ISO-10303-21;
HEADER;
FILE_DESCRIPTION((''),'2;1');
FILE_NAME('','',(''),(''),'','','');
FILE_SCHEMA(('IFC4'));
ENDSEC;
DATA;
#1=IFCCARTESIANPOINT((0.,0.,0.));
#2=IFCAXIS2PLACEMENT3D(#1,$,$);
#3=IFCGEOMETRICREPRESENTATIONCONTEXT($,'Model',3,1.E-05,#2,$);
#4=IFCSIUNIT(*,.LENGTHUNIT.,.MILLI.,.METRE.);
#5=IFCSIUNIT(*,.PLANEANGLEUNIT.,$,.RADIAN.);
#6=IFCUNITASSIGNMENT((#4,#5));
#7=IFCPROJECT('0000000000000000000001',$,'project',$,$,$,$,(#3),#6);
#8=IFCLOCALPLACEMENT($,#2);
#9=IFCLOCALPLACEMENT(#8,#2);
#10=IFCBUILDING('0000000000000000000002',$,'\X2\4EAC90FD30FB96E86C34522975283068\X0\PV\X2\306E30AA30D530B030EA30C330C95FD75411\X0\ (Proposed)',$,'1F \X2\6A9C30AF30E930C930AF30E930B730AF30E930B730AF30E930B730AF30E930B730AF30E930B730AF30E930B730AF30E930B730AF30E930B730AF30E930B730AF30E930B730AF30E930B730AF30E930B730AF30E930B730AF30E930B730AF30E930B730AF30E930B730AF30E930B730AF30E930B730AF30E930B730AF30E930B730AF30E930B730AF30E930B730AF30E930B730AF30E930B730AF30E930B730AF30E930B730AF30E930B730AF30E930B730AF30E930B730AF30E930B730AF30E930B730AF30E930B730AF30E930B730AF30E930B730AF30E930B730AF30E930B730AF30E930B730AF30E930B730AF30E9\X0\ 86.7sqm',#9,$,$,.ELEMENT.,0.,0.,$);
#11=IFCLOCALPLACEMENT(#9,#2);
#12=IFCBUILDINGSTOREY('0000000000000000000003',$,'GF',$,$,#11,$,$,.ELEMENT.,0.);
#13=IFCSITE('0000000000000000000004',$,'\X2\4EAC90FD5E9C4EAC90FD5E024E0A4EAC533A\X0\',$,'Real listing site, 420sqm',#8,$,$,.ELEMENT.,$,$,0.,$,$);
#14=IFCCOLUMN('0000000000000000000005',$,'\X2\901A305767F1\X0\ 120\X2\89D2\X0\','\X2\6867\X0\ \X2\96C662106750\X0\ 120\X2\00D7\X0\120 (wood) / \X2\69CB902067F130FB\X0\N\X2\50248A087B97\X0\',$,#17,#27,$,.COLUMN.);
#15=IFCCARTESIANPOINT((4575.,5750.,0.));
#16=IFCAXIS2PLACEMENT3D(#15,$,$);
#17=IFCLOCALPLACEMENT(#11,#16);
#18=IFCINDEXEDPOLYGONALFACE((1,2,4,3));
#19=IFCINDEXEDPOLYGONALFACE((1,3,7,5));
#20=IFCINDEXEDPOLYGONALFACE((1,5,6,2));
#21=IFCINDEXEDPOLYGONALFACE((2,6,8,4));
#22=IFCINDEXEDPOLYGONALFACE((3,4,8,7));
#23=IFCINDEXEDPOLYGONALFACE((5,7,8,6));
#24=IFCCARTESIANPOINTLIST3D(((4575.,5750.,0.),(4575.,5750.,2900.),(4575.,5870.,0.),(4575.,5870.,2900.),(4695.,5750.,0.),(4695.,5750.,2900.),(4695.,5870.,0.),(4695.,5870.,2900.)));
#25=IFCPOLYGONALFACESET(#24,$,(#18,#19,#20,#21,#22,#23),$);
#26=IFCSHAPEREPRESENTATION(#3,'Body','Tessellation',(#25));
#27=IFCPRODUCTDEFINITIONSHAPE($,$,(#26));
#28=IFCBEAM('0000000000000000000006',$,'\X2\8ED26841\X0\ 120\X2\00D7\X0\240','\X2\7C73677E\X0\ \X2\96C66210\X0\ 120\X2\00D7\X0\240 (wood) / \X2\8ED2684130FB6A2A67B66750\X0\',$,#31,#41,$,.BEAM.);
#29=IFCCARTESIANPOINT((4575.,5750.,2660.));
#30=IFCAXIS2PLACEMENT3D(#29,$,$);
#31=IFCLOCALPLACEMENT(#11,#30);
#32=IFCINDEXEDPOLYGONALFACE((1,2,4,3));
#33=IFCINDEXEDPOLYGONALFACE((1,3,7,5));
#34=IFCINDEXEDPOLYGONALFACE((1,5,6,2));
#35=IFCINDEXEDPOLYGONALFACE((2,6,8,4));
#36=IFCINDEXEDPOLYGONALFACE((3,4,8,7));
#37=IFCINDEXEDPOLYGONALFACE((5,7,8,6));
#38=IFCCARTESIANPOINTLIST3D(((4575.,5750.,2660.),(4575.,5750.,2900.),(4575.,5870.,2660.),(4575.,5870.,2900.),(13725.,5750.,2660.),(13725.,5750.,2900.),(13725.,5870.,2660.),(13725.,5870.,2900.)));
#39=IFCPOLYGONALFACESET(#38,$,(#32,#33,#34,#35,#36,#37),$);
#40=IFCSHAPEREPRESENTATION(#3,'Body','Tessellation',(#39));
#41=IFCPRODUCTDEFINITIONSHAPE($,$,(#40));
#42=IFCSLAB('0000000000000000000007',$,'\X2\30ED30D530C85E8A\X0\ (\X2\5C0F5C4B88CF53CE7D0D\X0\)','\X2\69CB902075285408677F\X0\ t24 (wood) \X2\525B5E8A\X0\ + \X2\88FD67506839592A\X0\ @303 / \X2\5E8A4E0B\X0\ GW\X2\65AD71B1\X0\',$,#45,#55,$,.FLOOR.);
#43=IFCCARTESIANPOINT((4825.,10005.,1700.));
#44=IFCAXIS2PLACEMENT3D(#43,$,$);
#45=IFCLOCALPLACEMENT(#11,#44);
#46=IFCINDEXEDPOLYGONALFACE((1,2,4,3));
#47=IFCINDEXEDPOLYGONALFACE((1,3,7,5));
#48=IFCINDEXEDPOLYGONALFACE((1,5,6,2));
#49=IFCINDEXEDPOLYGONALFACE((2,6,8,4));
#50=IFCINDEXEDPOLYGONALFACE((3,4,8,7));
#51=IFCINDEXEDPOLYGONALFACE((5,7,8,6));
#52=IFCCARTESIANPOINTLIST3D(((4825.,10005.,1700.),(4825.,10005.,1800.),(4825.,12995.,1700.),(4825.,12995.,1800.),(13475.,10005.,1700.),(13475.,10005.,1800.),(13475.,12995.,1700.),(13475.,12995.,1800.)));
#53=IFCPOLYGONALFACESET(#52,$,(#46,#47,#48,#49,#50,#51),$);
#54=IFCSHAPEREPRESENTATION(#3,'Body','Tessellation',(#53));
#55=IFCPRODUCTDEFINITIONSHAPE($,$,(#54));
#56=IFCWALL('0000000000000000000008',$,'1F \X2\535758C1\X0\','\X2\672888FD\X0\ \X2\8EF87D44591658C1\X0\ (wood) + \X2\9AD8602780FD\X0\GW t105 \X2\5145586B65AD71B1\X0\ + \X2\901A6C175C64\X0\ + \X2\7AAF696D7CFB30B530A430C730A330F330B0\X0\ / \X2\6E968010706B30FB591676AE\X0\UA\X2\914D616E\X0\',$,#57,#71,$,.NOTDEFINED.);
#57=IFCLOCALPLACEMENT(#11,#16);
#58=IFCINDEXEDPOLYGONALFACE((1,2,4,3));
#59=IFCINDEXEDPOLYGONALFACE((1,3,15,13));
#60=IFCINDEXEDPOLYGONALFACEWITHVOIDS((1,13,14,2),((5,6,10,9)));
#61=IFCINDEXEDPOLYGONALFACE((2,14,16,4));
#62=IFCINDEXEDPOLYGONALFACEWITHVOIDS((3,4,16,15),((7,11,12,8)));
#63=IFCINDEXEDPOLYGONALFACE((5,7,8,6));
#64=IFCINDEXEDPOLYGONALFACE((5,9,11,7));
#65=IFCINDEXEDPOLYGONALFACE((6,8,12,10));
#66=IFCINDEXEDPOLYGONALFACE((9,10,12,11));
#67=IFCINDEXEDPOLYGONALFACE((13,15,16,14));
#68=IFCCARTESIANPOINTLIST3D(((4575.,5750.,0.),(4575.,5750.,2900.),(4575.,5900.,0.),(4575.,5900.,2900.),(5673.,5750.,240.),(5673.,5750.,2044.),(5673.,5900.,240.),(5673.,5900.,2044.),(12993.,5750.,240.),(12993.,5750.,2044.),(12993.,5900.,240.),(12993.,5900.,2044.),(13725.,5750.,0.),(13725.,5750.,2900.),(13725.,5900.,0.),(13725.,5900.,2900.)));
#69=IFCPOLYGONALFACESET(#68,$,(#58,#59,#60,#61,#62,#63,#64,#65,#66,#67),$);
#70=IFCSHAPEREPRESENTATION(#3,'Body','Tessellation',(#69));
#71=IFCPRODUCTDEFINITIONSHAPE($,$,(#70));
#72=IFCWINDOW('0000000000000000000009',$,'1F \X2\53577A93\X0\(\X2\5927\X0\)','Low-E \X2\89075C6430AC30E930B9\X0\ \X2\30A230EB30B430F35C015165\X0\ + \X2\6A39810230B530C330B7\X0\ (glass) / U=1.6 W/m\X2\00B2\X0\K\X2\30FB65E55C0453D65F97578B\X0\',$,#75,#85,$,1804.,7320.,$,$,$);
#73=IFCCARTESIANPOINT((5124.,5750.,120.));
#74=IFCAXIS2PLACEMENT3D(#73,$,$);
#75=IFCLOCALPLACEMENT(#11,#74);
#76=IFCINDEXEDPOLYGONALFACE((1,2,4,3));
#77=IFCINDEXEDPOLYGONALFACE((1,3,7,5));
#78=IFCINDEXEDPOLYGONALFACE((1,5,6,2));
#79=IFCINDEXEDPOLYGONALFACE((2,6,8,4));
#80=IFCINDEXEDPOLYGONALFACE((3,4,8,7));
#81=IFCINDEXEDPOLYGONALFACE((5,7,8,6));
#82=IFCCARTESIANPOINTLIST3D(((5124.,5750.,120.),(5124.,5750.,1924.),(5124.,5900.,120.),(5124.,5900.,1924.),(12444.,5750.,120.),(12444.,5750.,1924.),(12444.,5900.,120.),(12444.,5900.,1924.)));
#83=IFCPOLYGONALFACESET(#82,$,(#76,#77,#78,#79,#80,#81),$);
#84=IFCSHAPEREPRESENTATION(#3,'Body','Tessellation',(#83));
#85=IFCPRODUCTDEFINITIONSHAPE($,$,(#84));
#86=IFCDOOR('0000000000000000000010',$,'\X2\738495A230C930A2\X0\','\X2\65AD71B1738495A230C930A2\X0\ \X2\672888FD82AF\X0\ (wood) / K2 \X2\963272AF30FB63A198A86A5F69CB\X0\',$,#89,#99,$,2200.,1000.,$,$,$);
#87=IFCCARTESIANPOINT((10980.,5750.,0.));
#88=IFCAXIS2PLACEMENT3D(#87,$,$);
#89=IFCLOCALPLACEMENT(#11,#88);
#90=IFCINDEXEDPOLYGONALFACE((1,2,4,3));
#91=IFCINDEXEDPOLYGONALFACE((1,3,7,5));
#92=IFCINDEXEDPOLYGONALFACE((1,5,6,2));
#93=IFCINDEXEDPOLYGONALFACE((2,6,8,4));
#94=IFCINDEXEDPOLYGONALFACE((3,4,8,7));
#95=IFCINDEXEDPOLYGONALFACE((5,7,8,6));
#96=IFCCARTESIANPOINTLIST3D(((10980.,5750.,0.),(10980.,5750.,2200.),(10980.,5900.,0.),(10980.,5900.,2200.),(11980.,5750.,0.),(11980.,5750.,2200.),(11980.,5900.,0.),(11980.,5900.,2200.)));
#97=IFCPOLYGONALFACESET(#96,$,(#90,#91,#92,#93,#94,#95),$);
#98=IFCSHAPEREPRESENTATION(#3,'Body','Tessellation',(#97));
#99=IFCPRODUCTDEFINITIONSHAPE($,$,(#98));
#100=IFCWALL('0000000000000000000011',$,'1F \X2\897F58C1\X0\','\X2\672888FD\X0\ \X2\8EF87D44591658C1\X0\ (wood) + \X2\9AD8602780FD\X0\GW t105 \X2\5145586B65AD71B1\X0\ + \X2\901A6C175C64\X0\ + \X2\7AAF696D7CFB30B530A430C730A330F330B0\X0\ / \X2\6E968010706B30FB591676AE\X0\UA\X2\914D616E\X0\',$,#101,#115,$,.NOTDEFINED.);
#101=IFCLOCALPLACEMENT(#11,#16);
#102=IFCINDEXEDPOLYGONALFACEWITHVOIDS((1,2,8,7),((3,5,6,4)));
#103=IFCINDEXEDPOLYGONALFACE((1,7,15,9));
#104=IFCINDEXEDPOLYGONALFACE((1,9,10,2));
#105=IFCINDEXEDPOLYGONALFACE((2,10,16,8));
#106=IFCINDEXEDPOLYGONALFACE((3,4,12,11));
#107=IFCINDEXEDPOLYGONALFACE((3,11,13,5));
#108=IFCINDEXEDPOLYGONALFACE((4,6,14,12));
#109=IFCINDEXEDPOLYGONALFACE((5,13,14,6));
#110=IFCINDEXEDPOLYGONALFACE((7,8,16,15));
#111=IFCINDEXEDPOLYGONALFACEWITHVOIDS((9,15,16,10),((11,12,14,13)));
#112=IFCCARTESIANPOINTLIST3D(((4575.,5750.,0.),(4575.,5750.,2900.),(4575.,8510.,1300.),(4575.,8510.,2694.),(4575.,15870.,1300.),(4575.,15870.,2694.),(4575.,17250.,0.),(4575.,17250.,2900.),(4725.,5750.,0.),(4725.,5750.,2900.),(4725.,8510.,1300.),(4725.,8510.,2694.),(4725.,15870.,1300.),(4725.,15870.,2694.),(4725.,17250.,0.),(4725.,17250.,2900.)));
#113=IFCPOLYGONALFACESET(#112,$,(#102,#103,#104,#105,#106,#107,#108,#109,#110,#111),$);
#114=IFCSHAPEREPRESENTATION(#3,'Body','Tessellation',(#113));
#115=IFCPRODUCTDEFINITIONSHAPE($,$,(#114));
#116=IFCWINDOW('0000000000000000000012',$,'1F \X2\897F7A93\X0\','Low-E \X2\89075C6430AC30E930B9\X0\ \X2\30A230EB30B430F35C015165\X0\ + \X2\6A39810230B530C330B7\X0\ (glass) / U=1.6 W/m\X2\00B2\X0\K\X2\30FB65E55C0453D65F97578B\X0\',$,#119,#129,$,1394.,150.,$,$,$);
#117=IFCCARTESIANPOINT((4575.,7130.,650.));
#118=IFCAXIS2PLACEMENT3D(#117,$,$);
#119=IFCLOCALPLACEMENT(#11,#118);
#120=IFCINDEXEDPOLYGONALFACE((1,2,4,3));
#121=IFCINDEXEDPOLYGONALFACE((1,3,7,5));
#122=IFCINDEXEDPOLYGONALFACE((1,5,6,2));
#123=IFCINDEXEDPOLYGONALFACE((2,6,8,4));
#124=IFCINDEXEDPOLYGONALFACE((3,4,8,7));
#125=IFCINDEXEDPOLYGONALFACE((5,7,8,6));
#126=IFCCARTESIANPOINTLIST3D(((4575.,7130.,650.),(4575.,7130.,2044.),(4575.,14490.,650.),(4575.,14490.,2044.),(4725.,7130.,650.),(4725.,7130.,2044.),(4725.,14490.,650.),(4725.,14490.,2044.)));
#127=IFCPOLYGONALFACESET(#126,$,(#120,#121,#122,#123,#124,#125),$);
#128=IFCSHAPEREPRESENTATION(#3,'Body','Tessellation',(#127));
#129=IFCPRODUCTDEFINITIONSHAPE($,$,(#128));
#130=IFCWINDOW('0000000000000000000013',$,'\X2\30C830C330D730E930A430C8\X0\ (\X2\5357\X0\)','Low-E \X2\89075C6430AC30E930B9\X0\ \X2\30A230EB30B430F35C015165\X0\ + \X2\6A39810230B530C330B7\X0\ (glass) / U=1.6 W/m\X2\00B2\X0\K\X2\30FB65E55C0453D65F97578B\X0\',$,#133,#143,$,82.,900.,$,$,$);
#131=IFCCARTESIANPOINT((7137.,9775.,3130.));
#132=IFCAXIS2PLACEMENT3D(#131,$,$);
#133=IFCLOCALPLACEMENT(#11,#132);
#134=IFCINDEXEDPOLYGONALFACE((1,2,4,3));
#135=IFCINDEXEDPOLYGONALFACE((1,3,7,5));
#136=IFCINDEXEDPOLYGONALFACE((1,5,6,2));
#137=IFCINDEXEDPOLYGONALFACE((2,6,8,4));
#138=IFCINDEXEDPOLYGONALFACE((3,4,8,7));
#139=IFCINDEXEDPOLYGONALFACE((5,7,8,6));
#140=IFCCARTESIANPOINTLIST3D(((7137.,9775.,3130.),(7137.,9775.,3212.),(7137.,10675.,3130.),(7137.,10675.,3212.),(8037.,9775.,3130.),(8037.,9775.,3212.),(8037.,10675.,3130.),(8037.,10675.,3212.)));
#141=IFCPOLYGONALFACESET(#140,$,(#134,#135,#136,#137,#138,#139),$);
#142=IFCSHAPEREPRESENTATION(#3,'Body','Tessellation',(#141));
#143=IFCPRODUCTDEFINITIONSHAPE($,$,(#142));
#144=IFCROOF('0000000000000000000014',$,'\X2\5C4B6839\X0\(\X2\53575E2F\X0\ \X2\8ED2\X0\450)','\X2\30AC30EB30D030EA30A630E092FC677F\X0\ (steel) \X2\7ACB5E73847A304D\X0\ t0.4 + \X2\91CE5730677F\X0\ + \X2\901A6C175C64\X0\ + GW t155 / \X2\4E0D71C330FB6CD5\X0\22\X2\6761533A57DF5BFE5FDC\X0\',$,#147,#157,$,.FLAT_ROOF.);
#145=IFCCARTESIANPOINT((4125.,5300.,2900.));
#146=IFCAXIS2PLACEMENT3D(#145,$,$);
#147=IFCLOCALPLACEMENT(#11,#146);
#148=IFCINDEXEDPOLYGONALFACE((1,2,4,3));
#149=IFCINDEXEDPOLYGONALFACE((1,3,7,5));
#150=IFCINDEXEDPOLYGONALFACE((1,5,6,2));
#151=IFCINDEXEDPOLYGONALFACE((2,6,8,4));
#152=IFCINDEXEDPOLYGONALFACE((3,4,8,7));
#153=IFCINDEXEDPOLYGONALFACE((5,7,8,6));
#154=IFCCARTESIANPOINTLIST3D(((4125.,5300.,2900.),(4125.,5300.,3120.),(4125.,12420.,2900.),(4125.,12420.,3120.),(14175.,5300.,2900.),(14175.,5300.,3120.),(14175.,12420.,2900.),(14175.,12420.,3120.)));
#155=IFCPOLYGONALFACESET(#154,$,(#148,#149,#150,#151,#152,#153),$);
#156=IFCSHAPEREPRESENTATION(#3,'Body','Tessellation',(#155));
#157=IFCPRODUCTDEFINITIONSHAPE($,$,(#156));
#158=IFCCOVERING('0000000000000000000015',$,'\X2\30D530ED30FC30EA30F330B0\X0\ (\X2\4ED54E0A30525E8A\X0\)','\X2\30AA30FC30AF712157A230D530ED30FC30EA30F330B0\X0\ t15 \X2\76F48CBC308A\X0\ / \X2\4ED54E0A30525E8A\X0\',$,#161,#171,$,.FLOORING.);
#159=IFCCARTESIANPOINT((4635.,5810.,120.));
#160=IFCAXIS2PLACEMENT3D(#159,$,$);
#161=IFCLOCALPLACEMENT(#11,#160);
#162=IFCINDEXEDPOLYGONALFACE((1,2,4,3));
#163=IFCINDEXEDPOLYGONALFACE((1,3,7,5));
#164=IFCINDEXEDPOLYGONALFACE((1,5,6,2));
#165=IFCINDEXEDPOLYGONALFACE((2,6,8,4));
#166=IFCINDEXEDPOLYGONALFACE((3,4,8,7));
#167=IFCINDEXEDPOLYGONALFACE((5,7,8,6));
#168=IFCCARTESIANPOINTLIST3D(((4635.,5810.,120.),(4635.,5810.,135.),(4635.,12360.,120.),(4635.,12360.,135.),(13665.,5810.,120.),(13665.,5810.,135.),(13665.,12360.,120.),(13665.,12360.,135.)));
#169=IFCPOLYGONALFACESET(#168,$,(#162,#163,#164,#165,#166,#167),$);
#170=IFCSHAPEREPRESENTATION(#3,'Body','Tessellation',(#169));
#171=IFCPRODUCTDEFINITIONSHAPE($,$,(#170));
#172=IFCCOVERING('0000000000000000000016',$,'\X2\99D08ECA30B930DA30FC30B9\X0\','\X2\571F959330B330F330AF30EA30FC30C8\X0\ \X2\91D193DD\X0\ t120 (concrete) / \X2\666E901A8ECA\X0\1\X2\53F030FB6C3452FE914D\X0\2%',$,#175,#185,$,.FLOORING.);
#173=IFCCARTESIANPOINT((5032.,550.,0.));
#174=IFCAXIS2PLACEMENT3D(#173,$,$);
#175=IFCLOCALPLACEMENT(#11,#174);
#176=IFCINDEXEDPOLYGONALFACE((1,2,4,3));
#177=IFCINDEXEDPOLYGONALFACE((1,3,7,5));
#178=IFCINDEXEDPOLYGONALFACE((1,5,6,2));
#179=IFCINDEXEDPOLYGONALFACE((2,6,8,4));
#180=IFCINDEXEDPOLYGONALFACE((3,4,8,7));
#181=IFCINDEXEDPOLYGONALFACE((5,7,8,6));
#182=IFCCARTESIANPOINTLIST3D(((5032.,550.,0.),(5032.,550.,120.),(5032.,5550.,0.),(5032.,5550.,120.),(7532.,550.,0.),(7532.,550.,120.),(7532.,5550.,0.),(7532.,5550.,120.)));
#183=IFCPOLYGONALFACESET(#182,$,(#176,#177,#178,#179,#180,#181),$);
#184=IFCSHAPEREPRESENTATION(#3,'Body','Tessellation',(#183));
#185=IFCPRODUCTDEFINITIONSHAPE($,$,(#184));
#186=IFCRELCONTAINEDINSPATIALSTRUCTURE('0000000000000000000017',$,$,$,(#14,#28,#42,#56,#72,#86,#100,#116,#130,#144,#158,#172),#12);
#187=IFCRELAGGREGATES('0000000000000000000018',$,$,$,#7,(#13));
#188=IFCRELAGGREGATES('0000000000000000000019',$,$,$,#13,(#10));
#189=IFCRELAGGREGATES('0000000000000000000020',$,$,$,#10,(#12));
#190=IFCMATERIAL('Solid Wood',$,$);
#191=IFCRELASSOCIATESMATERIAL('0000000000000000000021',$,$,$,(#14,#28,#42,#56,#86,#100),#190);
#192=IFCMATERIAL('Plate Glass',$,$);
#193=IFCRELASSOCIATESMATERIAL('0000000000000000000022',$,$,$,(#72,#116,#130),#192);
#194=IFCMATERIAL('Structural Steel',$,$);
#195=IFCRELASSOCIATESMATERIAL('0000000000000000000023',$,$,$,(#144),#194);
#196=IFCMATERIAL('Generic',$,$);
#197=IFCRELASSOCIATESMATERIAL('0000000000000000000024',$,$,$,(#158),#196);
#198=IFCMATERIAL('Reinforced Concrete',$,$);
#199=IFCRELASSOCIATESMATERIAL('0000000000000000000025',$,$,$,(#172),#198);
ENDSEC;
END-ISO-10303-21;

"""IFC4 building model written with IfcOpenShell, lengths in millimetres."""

from ifc_helpers import new_model, si_unit, frame, frame_2d, origin, place, context, project, spatial, rectangle, extrude, material, element, fill, save


model = new_model("IFC4")

# Units and contexts
model_context = context("Model", 3, precision=1e-05, world=origin())
ifc_project = project(units=[si_unit("LENGTHUNIT", "METRE", prefix="MILLI"), si_unit("PLANEANGLEUNIT", "RADIAN")], contexts=[model_context])

# Site, building, storey
site_placement = place(None, origin())
site = spatial("IfcSite", under=ifc_project, at=site_placement, Name="京都府京都市上京区", ObjectType="Real listing site, 420sqm", CompositionType="ELEMENT", RefElevation=0.0)
building_placement = place(site_placement, origin())
building = spatial("IfcBuilding", under=site, at=building_placement, Name="京都・雨水利用とPVのオフグリッド志向 (Proposed)", ObjectType="1F 檜クラドクラシクラシクラシクラシクラシクラシクラシクラシクラシクラシクラシクラシクラシクラシクラシクラシクラシクラシクラシクラシクラシクラシクラシクラシクラシクラシクラシクラシクラシクラシクラシクラシクラシクラシクラシクラシクラシクラシクラ 86.7sqm", CompositionType="ELEMENT", ElevationOfRefHeight=0.0, ElevationOfTerrain=0.0)
storey_placement = place(building_placement, origin())
storey = spatial("IfcBuildingStorey", under=building, at=storey_placement, Name="GF", CompositionType="ELEMENT", Elevation=0.0)

# Column
ifc_material_1 = material(Name="Solid Wood")
column_1_placement = place(storey_placement, frame((4575.0, 5750.0, 0.0)))
element("IfcColumn", 1, at=column_1_placement, inside=storey, material=ifc_material_1, Name="通し柱 120角", Description="桧 集成材 120×120 (wood) / 構造柱・N値計算", PredefinedType="COLUMN", context=model_context, shape_type="SweptSolid", body=[
    extrude(rectangle(XDim=120.0, YDim=120.0, at=frame_2d((60.0, 60.0))), frame((4575.0, 5750.0, 0.0)), (0.0, 0.0, 1.0), 2900.0),
])

# Beam
beam_1_placement = place(storey_placement, frame((4575.0, 5750.0, 2660.0)))
element("IfcBeam", 2, at=beam_1_placement, inside=storey, material=ifc_material_1, Name="軒桁 120×240", Description="米松 集成 120×240 (wood) / 軒桁・横架材", PredefinedType="BEAM", context=model_context, shape_type="SweptSolid", body=[
    extrude(rectangle(XDim=9150.0, YDim=120.0, at=frame_2d((4575.0, 60.0))), frame((4575.0, 5750.0, 2660.0)), (0.0, 0.0, 1.0), 240.0),
])

# Slab
ifc_material_2 = material(Name="Reinforced Concrete")
slab_1_placement = place(storey_placement, frame((4825.0, 10005.0, 1700.0)))
element("IfcSlab", 3, at=slab_1_placement, inside=storey, material=ifc_material_1, Name="ロフト床 (小屋裏収納)", Description="構造用合板 t24 (wood) 剛床 + 製材根太 @303 / 床下 GW断熱", PredefinedType="FLOOR", context=model_context, shape_type="SweptSolid", body=[
    extrude(rectangle(XDim=8650.0, YDim=2990.0, at=frame_2d((4325.0, 1495.0))), frame((4825.0, 10005.0, 1700.0)), (0.0, 0.0, 1.0), 100.0),
])

# Wall, openings, window, door
wall_1_placement = place(storey_placement, frame((4575.0, 5750.0, 0.0)))
wall_1 = element("IfcWall", 4, at=wall_1_placement, inside=storey, material=ifc_material_1, Name="1F 南壁", Description="木製 軸組外壁 (wood) + 高性能GW t105 充填断熱 + 通気層 + 窯業系サイディング / 準耐火・外皮UA配慮", PredefinedType="NOTDEFINED", context=model_context, shape_type="SweptSolid", body=[
    extrude(rectangle(XDim=9150.0, YDim=150.0, at=frame_2d((4575.0, 75.0))), frame((4575.0, 5750.0, 0.0)), (0.0, 0.0, 1.0), 2900.0),
])
opening_1_placement = place(storey_placement, frame((5124.0, 5750.0, 120.0)))
opening_1 = element("IfcOpeningElement", 5, at=opening_1_placement, cuts=wall_1, PredefinedType="NOTDEFINED", context=model_context, shape_type="SweptSolid", body=[
    extrude(rectangle(XDim=7320.0, YDim=150.0, at=frame_2d((3660.0, 75.0))), frame((5124.0, 5750.0, 120.0)), (0.0, 0.0, 1.0), 1804.0),
])
opening_2_placement = place(storey_placement, frame((10980.0, 5750.0, 0.0)))
opening_2 = element("IfcOpeningElement", 6, at=opening_2_placement, cuts=wall_1, PredefinedType="NOTDEFINED", context=model_context, shape_type="SweptSolid", body=[
    extrude(rectangle(XDim=1000.0, YDim=150.0, at=frame_2d((500.0, 75.0))), frame((10980.0, 5750.0, 0.0)), (0.0, 0.0, 1.0), 2200.0),
])
ifc_material_3 = material(Name="Plate Glass")
window_1_placement = place(storey_placement, frame((5124.0, 5750.0, 120.0)))
window_1 = element("IfcWindow", 7, at=window_1_placement, inside=storey, material=ifc_material_3, Name="1F 南窓(大)", Description="Low-E 複層ガラス アルゴン封入 + 樹脂サッシ (glass) / U=1.6 W/m²K・日射取得型", OverallHeight=1804.0, OverallWidth=7320.0, context=model_context, shape_type="SweptSolid", body=[
    extrude(rectangle(XDim=7320.0, YDim=150.0, at=frame_2d((3660.0, 75.0))), frame((5124.0, 5750.0, 120.0)), (0.0, 0.0, 1.0), 1804.0),
])
fill(opening_1, window_1)
door_placement = place(storey_placement, frame((10980.0, 5750.0, 0.0)))
door = element("IfcDoor", 8, at=door_placement, inside=storey, material=ifc_material_1, Name="玄関ドア", Description="断熱玄関ドア 木製芯 (wood) / K2 防犯・採風機構", OverallHeight=2200.0, OverallWidth=1000.0, context=model_context, shape_type="SweptSolid", body=[
    extrude(rectangle(XDim=1000.0, YDim=150.0, at=frame_2d((500.0, 75.0))), frame((10980.0, 5750.0, 0.0)), (0.0, 0.0, 1.0), 2200.0),
])
fill(opening_2, door)

# Wall, opening, window
wall_2_placement = place(storey_placement, frame((4575.0, 5750.0, 0.0)))
wall_2 = element("IfcWall", 9, at=wall_2_placement, inside=storey, material=ifc_material_1, Name="1F 西壁", Description="木製 軸組外壁 (wood) + 高性能GW t105 充填断熱 + 通気層 + 窯業系サイディング / 準耐火・外皮UA配慮", PredefinedType="NOTDEFINED", context=model_context, shape_type="SweptSolid", body=[
    extrude(rectangle(XDim=150.0, YDim=11500.0, at=frame_2d((75.0, 5750.0))), frame((4575.0, 5750.0, 0.0)), (0.0, 0.0, 1.0), 2900.0),
])
opening_3_placement = place(storey_placement, frame((4575.0, 7130.0, 650.0)))
opening_3 = element("IfcOpeningElement", 10, at=opening_3_placement, cuts=wall_2, PredefinedType="NOTDEFINED", context=model_context, shape_type="SweptSolid", body=[
    extrude(rectangle(XDim=150.0, YDim=7360.0, at=frame_2d((75.0, 3680.0))), frame((4575.0, 7130.0, 650.0)), (0.0, 0.0, 1.0), 1394.0),
])
window_2_placement = place(storey_placement, frame((4575.0, 7130.0, 650.0)))
window_2 = element("IfcWindow", 11, at=window_2_placement, inside=storey, material=ifc_material_3, Name="1F 西窓", Description="Low-E 複層ガラス アルゴン封入 + 樹脂サッシ (glass) / U=1.6 W/m²K・日射取得型", OverallHeight=1394.0, OverallWidth=150.0, context=model_context, shape_type="SweptSolid", body=[
    extrude(rectangle(XDim=150.0, YDim=7360.0, at=frame_2d((75.0, 3680.0))), frame((4575.0, 7130.0, 650.0)), (0.0, 0.0, 1.0), 1394.0),
])
fill(opening_3, window_2)

# Window
window_3_placement = place(storey_placement, frame((7137.0, 9775.0, 3130.0)))
element("IfcWindow", 12, at=window_3_placement, inside=storey, material=ifc_material_3, Name="トップライト (南)", Description="Low-E 複層ガラス アルゴン封入 + 樹脂サッシ (glass) / U=1.6 W/m²K・日射取得型", OverallHeight=82.0, OverallWidth=900.0, context=model_context, shape_type="SweptSolid", body=[
    extrude(rectangle(XDim=900.0, YDim=900.0, at=frame_2d((450.0, 450.0))), frame((7137.0, 9775.0, 3130.0)), (0.0, 0.0, 1.0), 82.0),
])

# Roof
ifc_material_4 = material(Name="Structural Steel")
roof_placement = place(storey_placement, frame((4125.0, 5300.0, 2900.0)))
element("IfcRoof", 13, at=roof_placement, inside=storey, material=ifc_material_4, Name="屋根(南帯 軒450)", Description="ガルバリウム鋼板 (steel) 立平葺き t0.4 + 野地板 + 通気層 + GW t155 / 不燃・法22条区域対応", PredefinedType="FLAT_ROOF", context=model_context, shape_type="SweptSolid", body=[
    extrude(rectangle(XDim=10050.0, YDim=7120.0, at=frame_2d((5025.0, 3560.0))), frame((4125.0, 5300.0, 2900.0)), (0.0, 0.0, 1.0), 220.0),
])

# Coverings
ifc_material_5 = material(Name="Generic")
covering_1_placement = place(storey_placement, frame((4635.0, 5810.0, 120.0)))
element("IfcCovering", 14, at=covering_1_placement, inside=storey, material=ifc_material_5, Name="フローリング (仕上げ床)", Description="オーク無垢フローリング t15 直貼り / 仕上げ床", PredefinedType="FLOORING", context=model_context, shape_type="SweptSolid", body=[
    extrude(rectangle(XDim=9030.0, YDim=6550.0, at=frame_2d((4515.0, 3275.0))), frame((4635.0, 5810.0, 120.0)), (0.0, 0.0, 1.0), 15.0),
])
covering_2_placement = place(storey_placement, frame((5032.0, 550.0, 0.0)))
element("IfcCovering", 15, at=covering_2_placement, inside=storey, material=ifc_material_2, Name="駐車スペース", Description="土間コンクリート 金鏝 t120 (concrete) / 普通車1台・水勾配2%", PredefinedType="FLOORING", context=model_context, shape_type="SweptSolid", body=[
    extrude(rectangle(XDim=2500.0, YDim=5000.0, at=frame_2d((1250.0, 2500.0))), frame((5032.0, 550.0, 0.0)), (0.0, 0.0, 1.0), 120.0),
])

save(model, "model.ifc")
